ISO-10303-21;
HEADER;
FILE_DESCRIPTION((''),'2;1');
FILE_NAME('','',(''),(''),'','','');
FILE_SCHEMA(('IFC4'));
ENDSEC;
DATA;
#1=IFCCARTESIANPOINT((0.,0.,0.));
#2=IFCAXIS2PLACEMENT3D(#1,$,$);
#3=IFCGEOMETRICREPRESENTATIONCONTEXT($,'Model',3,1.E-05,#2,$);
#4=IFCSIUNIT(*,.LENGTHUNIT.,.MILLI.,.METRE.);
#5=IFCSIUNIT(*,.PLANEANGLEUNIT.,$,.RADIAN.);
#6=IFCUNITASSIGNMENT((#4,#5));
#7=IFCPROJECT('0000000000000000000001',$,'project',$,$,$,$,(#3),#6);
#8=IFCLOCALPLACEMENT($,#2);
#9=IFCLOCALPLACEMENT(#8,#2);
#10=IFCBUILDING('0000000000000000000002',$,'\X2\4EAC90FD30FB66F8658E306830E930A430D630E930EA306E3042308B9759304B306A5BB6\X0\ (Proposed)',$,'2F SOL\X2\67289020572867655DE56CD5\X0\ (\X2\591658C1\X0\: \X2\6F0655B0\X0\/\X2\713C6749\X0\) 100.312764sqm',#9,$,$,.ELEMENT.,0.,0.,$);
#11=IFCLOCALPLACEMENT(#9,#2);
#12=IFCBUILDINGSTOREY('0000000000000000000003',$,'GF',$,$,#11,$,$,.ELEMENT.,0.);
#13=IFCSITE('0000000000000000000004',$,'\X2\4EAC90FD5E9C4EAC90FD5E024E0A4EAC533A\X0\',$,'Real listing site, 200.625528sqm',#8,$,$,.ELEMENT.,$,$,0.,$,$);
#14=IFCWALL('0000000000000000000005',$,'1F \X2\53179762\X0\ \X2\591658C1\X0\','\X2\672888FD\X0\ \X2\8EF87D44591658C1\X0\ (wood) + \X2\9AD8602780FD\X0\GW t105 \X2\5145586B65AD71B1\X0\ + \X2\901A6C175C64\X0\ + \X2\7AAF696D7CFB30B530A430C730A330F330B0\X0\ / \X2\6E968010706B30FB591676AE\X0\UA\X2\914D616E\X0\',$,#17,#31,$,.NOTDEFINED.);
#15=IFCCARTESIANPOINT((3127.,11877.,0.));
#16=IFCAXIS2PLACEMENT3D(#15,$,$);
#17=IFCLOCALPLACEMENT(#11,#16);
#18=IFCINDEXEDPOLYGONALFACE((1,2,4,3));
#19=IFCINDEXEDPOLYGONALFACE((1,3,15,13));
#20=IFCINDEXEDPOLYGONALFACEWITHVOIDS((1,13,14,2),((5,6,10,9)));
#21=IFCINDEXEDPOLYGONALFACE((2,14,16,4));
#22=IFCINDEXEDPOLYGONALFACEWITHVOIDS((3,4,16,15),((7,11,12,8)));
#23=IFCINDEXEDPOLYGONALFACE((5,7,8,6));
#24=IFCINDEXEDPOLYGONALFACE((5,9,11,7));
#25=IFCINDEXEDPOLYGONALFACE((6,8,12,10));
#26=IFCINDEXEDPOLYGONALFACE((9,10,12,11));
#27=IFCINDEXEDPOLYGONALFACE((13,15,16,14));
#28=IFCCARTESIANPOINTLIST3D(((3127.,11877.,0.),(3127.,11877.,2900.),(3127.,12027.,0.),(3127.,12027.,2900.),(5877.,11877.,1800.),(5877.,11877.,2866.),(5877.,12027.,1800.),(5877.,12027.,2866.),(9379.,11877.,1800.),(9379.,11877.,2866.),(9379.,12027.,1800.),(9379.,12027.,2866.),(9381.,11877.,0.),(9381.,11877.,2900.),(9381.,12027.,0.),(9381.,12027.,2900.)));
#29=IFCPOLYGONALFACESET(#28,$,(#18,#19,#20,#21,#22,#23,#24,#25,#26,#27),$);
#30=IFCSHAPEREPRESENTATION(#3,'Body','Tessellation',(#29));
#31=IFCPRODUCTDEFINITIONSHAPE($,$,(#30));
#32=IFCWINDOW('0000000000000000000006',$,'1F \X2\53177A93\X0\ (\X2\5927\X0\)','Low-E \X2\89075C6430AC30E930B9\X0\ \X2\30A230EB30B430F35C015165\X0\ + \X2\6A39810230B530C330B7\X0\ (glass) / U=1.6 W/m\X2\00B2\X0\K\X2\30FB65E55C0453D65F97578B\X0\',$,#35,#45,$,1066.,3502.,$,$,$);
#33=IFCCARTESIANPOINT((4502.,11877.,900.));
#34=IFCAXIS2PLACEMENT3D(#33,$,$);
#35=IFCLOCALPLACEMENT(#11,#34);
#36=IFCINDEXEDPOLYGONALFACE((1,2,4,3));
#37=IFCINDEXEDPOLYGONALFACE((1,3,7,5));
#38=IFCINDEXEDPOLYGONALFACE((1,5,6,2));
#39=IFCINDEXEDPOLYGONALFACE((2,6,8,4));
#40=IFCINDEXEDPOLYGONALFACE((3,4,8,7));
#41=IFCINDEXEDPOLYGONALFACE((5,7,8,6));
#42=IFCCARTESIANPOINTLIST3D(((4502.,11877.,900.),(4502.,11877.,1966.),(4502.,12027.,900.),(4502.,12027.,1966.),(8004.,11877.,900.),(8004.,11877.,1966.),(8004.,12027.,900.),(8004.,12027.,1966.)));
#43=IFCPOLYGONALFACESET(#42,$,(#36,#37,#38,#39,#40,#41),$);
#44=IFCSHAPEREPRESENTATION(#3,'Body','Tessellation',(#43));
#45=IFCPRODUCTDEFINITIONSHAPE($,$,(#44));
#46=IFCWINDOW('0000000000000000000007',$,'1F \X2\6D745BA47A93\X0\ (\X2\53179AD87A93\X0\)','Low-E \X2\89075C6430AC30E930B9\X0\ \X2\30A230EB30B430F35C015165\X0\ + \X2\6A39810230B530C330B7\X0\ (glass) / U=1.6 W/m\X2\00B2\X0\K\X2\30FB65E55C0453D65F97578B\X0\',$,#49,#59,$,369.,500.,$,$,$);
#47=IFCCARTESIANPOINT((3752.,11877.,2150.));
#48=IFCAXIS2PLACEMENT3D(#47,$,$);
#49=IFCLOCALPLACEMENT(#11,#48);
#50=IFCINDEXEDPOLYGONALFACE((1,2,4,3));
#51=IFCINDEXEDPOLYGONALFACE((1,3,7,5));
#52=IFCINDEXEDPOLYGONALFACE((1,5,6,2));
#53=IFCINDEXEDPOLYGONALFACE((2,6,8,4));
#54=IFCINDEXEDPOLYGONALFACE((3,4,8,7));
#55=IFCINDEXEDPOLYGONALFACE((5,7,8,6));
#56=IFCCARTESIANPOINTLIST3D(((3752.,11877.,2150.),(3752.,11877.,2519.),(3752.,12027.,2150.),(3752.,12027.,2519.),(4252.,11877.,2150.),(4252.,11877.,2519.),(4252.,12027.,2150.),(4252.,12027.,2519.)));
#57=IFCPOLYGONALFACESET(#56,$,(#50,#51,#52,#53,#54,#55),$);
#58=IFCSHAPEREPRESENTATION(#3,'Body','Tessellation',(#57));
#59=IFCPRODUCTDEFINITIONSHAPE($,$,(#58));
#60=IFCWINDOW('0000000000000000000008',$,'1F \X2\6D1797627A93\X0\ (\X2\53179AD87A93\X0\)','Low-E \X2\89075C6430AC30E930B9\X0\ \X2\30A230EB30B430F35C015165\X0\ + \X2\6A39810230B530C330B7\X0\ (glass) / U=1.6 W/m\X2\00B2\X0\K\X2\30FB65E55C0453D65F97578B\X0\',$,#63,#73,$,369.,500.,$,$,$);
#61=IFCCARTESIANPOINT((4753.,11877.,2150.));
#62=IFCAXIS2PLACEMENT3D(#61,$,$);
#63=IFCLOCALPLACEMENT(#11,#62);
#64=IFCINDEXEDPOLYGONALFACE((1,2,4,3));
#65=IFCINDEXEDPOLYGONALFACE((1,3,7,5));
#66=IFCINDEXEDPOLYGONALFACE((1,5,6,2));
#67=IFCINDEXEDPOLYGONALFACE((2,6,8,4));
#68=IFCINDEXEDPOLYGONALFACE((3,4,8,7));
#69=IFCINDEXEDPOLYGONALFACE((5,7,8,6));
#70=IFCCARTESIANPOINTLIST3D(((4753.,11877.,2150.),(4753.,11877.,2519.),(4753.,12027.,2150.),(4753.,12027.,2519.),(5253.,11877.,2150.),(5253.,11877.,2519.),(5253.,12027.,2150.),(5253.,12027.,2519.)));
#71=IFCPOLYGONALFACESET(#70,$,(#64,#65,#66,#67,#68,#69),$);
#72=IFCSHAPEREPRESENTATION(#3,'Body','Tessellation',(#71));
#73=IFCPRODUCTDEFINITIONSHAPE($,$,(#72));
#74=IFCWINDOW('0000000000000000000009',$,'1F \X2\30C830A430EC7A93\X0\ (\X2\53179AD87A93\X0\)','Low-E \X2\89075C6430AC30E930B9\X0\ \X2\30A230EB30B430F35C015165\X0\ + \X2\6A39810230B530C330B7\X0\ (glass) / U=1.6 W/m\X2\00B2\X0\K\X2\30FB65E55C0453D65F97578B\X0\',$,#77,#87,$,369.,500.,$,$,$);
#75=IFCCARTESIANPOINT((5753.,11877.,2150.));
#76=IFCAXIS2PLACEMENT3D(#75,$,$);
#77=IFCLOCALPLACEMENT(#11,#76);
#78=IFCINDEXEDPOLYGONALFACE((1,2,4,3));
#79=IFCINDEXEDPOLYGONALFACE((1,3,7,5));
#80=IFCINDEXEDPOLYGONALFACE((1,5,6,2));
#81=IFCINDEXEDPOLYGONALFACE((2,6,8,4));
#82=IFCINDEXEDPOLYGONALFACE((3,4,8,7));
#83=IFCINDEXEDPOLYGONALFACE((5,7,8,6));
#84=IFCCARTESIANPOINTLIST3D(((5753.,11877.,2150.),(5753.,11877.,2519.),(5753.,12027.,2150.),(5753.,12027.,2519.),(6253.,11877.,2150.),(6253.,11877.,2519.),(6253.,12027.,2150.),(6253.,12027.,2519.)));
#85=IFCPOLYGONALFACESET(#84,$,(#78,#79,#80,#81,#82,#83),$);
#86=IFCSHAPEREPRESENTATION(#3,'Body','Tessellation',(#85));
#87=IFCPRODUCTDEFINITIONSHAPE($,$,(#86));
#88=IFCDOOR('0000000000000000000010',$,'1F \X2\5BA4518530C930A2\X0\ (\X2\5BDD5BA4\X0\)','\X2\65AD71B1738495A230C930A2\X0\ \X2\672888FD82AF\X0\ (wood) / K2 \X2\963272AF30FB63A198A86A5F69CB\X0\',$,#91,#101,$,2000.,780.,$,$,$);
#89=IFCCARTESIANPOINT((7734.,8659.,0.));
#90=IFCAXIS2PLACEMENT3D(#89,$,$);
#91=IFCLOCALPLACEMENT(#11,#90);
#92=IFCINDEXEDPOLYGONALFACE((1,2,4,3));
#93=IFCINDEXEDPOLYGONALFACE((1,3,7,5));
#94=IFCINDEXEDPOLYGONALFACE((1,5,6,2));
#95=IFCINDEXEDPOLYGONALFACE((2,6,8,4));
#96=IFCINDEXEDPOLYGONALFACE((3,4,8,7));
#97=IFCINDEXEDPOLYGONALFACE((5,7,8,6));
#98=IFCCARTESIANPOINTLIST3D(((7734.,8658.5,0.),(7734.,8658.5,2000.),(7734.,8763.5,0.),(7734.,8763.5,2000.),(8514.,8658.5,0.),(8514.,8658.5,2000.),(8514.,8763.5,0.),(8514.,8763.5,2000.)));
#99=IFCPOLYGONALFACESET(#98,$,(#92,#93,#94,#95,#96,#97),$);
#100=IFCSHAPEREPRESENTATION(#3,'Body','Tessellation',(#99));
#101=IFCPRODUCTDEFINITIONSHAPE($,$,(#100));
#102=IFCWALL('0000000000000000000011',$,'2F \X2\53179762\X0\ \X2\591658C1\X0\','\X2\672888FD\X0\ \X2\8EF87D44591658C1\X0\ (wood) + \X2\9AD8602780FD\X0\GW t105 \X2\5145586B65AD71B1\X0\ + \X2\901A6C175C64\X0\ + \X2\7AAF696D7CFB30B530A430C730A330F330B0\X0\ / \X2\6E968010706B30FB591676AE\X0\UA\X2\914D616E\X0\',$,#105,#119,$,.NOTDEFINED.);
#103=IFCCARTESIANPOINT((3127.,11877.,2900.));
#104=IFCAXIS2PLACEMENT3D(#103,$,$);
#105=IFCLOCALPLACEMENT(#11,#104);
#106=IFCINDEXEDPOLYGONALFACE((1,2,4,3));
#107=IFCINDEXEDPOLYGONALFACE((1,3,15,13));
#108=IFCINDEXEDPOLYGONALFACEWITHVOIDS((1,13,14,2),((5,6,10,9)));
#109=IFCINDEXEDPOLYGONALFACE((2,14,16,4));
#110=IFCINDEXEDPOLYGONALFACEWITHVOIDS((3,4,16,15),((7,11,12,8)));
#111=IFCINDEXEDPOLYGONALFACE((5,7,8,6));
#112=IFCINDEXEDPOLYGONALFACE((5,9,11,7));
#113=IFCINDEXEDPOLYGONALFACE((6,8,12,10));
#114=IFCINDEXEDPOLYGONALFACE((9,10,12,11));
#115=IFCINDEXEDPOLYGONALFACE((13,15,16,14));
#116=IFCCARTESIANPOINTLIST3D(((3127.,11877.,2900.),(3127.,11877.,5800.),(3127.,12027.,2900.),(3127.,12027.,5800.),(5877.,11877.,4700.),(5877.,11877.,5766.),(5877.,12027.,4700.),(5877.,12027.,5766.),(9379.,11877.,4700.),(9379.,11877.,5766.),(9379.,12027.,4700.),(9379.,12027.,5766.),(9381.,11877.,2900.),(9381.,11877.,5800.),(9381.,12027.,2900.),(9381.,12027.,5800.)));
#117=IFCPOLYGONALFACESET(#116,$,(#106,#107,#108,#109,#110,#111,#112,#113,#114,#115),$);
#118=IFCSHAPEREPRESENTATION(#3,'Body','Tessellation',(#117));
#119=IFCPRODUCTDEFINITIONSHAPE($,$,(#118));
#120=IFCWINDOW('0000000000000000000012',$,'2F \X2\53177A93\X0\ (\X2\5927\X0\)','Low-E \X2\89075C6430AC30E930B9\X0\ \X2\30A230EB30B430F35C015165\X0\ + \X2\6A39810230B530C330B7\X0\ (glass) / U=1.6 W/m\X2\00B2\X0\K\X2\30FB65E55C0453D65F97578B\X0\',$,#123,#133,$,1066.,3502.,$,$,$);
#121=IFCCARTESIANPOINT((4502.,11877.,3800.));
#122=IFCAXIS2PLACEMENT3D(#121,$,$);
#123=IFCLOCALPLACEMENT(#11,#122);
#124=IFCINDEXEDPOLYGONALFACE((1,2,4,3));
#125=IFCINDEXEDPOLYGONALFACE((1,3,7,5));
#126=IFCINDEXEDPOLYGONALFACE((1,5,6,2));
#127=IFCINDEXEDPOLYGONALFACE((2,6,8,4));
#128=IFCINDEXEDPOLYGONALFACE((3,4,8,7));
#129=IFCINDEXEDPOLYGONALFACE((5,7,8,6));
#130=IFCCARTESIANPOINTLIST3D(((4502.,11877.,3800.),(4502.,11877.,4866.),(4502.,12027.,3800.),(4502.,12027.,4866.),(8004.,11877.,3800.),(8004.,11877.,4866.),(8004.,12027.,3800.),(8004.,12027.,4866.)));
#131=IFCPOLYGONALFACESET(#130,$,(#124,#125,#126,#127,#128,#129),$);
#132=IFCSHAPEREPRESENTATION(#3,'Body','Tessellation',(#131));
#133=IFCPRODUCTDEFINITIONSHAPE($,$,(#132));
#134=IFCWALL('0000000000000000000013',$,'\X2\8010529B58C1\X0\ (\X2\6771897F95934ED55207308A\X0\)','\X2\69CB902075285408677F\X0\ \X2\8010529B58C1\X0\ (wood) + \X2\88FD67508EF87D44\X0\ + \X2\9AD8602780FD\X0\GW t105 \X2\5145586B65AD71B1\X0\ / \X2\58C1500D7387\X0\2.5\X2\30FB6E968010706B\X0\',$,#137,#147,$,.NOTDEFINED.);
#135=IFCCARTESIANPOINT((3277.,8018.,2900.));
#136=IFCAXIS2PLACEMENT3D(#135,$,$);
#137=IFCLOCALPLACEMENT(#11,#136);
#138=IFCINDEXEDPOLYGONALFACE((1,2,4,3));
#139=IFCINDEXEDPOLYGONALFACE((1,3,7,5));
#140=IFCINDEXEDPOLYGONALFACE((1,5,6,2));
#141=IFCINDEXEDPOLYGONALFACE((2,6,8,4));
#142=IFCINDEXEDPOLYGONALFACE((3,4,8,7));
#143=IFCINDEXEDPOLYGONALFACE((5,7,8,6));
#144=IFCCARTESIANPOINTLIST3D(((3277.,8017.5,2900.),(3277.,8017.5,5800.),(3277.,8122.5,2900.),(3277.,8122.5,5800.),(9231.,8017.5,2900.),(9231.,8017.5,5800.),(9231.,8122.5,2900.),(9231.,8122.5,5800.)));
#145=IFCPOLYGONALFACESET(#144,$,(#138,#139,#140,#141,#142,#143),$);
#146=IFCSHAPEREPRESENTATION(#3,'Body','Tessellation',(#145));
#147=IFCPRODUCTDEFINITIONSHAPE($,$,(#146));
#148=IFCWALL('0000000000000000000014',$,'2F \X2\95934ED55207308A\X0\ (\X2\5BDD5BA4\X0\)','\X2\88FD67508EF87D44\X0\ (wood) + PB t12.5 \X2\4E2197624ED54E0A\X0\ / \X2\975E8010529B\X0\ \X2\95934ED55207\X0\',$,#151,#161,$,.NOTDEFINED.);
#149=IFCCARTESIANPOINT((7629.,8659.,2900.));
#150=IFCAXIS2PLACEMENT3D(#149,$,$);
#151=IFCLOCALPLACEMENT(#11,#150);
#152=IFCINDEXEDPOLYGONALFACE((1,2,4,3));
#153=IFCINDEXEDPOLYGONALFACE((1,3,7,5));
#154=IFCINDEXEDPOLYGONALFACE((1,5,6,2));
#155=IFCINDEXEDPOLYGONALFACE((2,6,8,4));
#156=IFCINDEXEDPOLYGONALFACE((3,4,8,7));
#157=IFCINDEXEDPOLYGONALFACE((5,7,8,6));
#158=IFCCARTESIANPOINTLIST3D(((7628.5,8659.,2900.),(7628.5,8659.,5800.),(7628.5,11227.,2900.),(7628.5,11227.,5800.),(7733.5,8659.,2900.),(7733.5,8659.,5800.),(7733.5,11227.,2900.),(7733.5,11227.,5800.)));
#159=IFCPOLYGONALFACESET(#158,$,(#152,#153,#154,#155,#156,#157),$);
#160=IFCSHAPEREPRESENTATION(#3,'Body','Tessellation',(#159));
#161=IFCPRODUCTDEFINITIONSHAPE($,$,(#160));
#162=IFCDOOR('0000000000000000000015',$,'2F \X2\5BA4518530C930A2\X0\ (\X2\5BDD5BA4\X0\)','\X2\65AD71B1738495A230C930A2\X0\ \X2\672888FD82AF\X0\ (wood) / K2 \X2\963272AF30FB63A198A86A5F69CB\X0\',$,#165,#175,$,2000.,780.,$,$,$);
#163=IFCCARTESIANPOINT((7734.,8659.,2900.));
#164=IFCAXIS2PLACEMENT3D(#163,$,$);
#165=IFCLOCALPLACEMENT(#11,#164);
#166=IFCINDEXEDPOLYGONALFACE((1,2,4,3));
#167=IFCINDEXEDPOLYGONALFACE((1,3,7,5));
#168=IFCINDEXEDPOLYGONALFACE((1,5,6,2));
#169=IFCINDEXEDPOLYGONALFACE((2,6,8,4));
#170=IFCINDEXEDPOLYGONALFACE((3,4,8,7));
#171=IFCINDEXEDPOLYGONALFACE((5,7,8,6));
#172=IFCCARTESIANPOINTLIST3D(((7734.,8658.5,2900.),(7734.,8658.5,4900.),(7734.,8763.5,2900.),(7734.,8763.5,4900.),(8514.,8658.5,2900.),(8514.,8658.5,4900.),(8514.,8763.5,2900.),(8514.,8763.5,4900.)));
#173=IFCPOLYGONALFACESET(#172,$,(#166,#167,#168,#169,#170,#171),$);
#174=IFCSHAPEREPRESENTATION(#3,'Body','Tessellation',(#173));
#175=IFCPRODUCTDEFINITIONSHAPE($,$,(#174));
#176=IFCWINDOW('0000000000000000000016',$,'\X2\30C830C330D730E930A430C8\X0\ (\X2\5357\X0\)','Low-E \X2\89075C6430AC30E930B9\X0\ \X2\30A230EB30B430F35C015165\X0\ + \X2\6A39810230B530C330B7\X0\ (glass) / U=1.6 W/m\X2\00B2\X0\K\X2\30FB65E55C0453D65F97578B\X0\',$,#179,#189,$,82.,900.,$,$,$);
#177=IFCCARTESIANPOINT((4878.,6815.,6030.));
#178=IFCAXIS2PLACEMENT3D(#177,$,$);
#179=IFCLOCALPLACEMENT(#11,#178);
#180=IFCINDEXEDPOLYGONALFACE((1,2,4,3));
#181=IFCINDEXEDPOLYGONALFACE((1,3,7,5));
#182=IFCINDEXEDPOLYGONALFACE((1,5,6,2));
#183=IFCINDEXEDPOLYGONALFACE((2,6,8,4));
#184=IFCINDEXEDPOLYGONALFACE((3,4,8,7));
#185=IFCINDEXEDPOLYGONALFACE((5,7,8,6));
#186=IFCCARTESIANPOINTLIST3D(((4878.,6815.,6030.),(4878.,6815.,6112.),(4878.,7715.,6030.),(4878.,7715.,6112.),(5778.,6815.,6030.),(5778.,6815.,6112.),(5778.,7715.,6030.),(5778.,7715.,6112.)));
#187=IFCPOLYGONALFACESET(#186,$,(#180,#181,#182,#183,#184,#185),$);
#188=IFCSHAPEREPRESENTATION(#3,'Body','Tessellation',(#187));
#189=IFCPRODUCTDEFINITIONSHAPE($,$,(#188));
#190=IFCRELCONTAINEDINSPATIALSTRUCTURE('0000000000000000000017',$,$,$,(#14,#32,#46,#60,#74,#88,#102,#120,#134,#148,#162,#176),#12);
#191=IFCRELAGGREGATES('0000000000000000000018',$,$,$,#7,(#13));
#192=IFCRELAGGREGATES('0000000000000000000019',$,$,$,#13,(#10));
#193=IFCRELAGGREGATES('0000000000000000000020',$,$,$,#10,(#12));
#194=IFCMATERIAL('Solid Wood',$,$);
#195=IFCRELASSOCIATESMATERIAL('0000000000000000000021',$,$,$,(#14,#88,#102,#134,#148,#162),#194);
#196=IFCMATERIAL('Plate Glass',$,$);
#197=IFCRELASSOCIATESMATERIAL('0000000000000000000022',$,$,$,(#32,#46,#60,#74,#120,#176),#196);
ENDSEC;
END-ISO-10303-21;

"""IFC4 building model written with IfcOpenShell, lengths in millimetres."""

from ifc_helpers import new_model, si_unit, frame, frame_2d, origin, place, context, project, spatial, rectangle, extrude, material, element, fill, save


model = new_model("IFC4")

# Units and contexts
model_context = context("Model", 3, precision=1e-05, world=origin())
ifc_project = project(units=[si_unit("LENGTHUNIT", "METRE", prefix="MILLI"), si_unit("PLANEANGLEUNIT", "RADIAN")], contexts=[model_context])

# Site, building, storey
site_placement = place(None, origin())
site = spatial("IfcSite", under=ifc_project, at=site_placement, Name="京都府京都市上京区", ObjectType="Real listing site, 200.625528sqm", CompositionType="ELEMENT", RefElevation=0.0)
building_placement = place(site_placement, origin())
building = spatial("IfcBuilding", under=site, at=building_placement, Name="京都・書斎とライブラリのある静かな家 (Proposed)", ObjectType="2F SOL木造在来工法 (外壁: 漆喰/焼杉) 100.312764sqm", CompositionType="ELEMENT", ElevationOfRefHeight=0.0, ElevationOfTerrain=0.0)
storey_placement = place(building_placement, origin())
storey = spatial("IfcBuildingStorey", under=building, at=storey_placement, Name="GF", CompositionType="ELEMENT", Elevation=0.0)

# Wall, openings, windows
ifc_material_1 = material(Name="Solid Wood")
wall_1_placement = place(storey_placement, frame((3127.0, 11877.0, 0.0)))
wall_1 = element("IfcWall", 1, at=wall_1_placement, inside=storey, material=ifc_material_1, Name="1F 北面 外壁", Description="木製 軸組外壁 (wood) + 高性能GW t105 充填断熱 + 通気層 + 窯業系サイディング / 準耐火・外皮UA配慮", PredefinedType="NOTDEFINED", context=model_context, shape_type="SweptSolid", body=[
    extrude(rectangle(XDim=6254.0, YDim=150.0, at=frame_2d((3127.0, 75.0))), frame((3127.0, 11877.0, 0.0)), (0.0, 0.0, 1.0), 2900.0),
])
opening_1_placement = place(storey_placement, frame((4502.0, 11877.0, 900.0)))
opening_1 = element("IfcOpeningElement", 2, at=opening_1_placement, cuts=wall_1, PredefinedType="NOTDEFINED", context=model_context, shape_type="SweptSolid", body=[
    extrude(rectangle(XDim=3502.0, YDim=150.0, at=frame_2d((1751.0, 75.0))), frame((4502.0, 11877.0, 900.0)), (0.0, 0.0, 1.0), 1066.0),
])
opening_2_placement = place(storey_placement, frame((3752.0, 11877.0, 2150.0)))
opening_2 = element("IfcOpeningElement", 3, at=opening_2_placement, cuts=wall_1, PredefinedType="NOTDEFINED", context=model_context, shape_type="SweptSolid", body=[
    extrude(rectangle(XDim=500.0, YDim=150.0, at=frame_2d((250.0, 75.0))), frame((3752.0, 11877.0, 2150.0)), (0.0, 0.0, 1.0), 369.0),
])
opening_3_placement = place(storey_placement, frame((4753.0, 11877.0, 2150.0)))
opening_3 = element("IfcOpeningElement", 4, at=opening_3_placement, cuts=wall_1, PredefinedType="NOTDEFINED", context=model_context, shape_type="SweptSolid", body=[
    extrude(rectangle(XDim=500.0, YDim=150.0, at=frame_2d((250.0, 75.0))), frame((4753.0, 11877.0, 2150.0)), (0.0, 0.0, 1.0), 369.0),
])
opening_4_placement = place(storey_placement, frame((5753.0, 11877.0, 2150.0)))
opening_4 = element("IfcOpeningElement", 5, at=opening_4_placement, cuts=wall_1, PredefinedType="NOTDEFINED", context=model_context, shape_type="SweptSolid", body=[
    extrude(rectangle(XDim=500.0, YDim=150.0, at=frame_2d((250.0, 75.0))), frame((5753.0, 11877.0, 2150.0)), (0.0, 0.0, 1.0), 369.0),
])
ifc_material_2 = material(Name="Plate Glass")
window_1_placement = place(storey_placement, frame((4502.0, 11877.0, 900.0)))
window_1 = element("IfcWindow", 6, at=window_1_placement, inside=storey, material=ifc_material_2, Name="1F 北窓 (大)", Description="Low-E 複層ガラス アルゴン封入 + 樹脂サッシ (glass) / U=1.6 W/m²K・日射取得型", OverallHeight=1066.0, OverallWidth=3502.0, context=model_context, shape_type="SweptSolid", body=[
    extrude(rectangle(XDim=3502.0, YDim=150.0, at=frame_2d((1751.0, 75.0))), frame((4502.0, 11877.0, 900.0)), (0.0, 0.0, 1.0), 1066.0),
])
fill(opening_1, window_1)
window_2_placement = place(storey_placement, frame((3752.0, 11877.0, 2150.0)))
window_2 = element("IfcWindow", 7, at=window_2_placement, inside=storey, material=ifc_material_2, Name="1F 浴室窓 (北高窓)", Description="Low-E 複層ガラス アルゴン封入 + 樹脂サッシ (glass) / U=1.6 W/m²K・日射取得型", OverallHeight=369.0, OverallWidth=500.0, context=model_context, shape_type="SweptSolid", body=[
    extrude(rectangle(XDim=500.0, YDim=150.0, at=frame_2d((250.0, 75.0))), frame((3752.0, 11877.0, 2150.0)), (0.0, 0.0, 1.0), 369.0),
])
fill(opening_2, window_2)
window_3_placement = place(storey_placement, frame((4753.0, 11877.0, 2150.0)))
window_3 = element("IfcWindow", 8, at=window_3_placement, inside=storey, material=ifc_material_2, Name="1F 洗面窓 (北高窓)", Description="Low-E 複層ガラス アルゴン封入 + 樹脂サッシ (glass) / U=1.6 W/m²K・日射取得型", OverallHeight=369.0, OverallWidth=500.0, context=model_context, shape_type="SweptSolid", body=[
    extrude(rectangle(XDim=500.0, YDim=150.0, at=frame_2d((250.0, 75.0))), frame((4753.0, 11877.0, 2150.0)), (0.0, 0.0, 1.0), 369.0),
])
fill(opening_3, window_3)
window_4_placement = place(storey_placement, frame((5753.0, 11877.0, 2150.0)))
window_4 = element("IfcWindow", 9, at=window_4_placement, inside=storey, material=ifc_material_2, Name="1F トイレ窓 (北高窓)", Description="Low-E 複層ガラス アルゴン封入 + 樹脂サッシ (glass) / U=1.6 W/m²K・日射取得型", OverallHeight=369.0, OverallWidth=500.0, context=model_context, shape_type="SweptSolid", body=[
    extrude(rectangle(XDim=500.0, YDim=150.0, at=frame_2d((250.0, 75.0))), frame((5753.0, 11877.0, 2150.0)), (0.0, 0.0, 1.0), 369.0),
])
fill(opening_4, window_4)

# Door
door_1_placement = place(storey_placement, frame((7734.0, 8659.0, 0.0)))
element("IfcDoor", 10, at=door_1_placement, inside=storey, material=ifc_material_1, Name="1F 室内ドア (寝室)", Description="断熱玄関ドア 木製芯 (wood) / K2 防犯・採風機構", OverallHeight=2000.0, OverallWidth=780.0, context=model_context, shape_type="SweptSolid", body=[
    extrude(rectangle(XDim=780.0, YDim=105.0, at=frame_2d((390.0, 52.0))), frame((7734.0, 8659.0, 0.0)), (0.0, 0.0, 1.0), 2000.0),
])

# Wall, opening, window
wall_2_placement = place(storey_placement, frame((3127.0, 11877.0, 2900.0)))
wall_2 = element("IfcWall", 11, at=wall_2_placement, inside=storey, material=ifc_material_1, Name="2F 北面 外壁", Description="木製 軸組外壁 (wood) + 高性能GW t105 充填断熱 + 通気層 + 窯業系サイディング / 準耐火・外皮UA配慮", PredefinedType="NOTDEFINED", context=model_context, shape_type="SweptSolid", body=[
    extrude(rectangle(XDim=6254.0, YDim=150.0, at=frame_2d((3127.0, 75.0))), frame((3127.0, 11877.0, 2900.0)), (0.0, 0.0, 1.0), 2900.0),
])
opening_5_placement = place(storey_placement, frame((4502.0, 11877.0, 3800.0)))
opening_5 = element("IfcOpeningElement", 12, at=opening_5_placement, cuts=wall_2, PredefinedType="NOTDEFINED", context=model_context, shape_type="SweptSolid", body=[
    extrude(rectangle(XDim=3502.0, YDim=150.0, at=frame_2d((1751.0, 75.0))), frame((4502.0, 11877.0, 3800.0)), (0.0, 0.0, 1.0), 1066.0),
])
window_5_placement = place(storey_placement, frame((4502.0, 11877.0, 3800.0)))
window_5 = element("IfcWindow", 13, at=window_5_placement, inside=storey, material=ifc_material_2, Name="2F 北窓 (大)", Description="Low-E 複層ガラス アルゴン封入 + 樹脂サッシ (glass) / U=1.6 W/m²K・日射取得型", OverallHeight=1066.0, OverallWidth=3502.0, context=model_context, shape_type="SweptSolid", body=[
    extrude(rectangle(XDim=3502.0, YDim=150.0, at=frame_2d((1751.0, 75.0))), frame((4502.0, 11877.0, 3800.0)), (0.0, 0.0, 1.0), 1066.0),
])
fill(opening_5, window_5)

# Walls
wall_3_placement = place(storey_placement, frame((3277.0, 8018.0, 2900.0)))
element("IfcWall", 14, at=wall_3_placement, inside=storey, material=ifc_material_1, Name="耐力壁 (東西間仕切り)", Description="構造用合板 耐力壁 (wood) + 製材軸組 + 高性能GW t105 充填断熱 / 壁倍率2.5・準耐火", PredefinedType="NOTDEFINED", context=model_context, shape_type="SweptSolid", body=[
    extrude(rectangle(XDim=5954.0, YDim=105.0, at=frame_2d((2977.0, 52.0))), frame((3277.0, 8018.0, 2900.0)), (0.0, 0.0, 1.0), 2900.0),
])
wall_4_placement = place(storey_placement, frame((7629.0, 8659.0, 2900.0)))
element("IfcWall", 15, at=wall_4_placement, inside=storey, material=ifc_material_1, Name="2F 間仕切り (寝室)", Description="製材軸組 (wood) + PB t12.5 両面仕上 / 非耐力 間仕切", PredefinedType="NOTDEFINED", context=model_context, shape_type="SweptSolid", body=[
    extrude(rectangle(XDim=105.0, YDim=2568.0, at=frame_2d((52.0, 1284.0))), frame((7629.0, 8659.0, 2900.0)), (0.0, 0.0, 1.0), 2900.0),
])

# Door
door_2_placement = place(storey_placement, frame((7734.0, 8659.0, 2900.0)))
element("IfcDoor", 16, at=door_2_placement, inside=storey, material=ifc_material_1, Name="2F 室内ドア (寝室)", Description="断熱玄関ドア 木製芯 (wood) / K2 防犯・採風機構", OverallHeight=2000.0, OverallWidth=780.0, context=model_context, shape_type="SweptSolid", body=[
    extrude(rectangle(XDim=780.0, YDim=105.0, at=frame_2d((390.0, 52.0))), frame((7734.0, 8659.0, 2900.0)), (0.0, 0.0, 1.0), 2000.0),
])

# Window
window_6_placement = place(storey_placement, frame((4878.0, 6815.0, 6030.0)))
element("IfcWindow", 17, at=window_6_placement, inside=storey, material=ifc_material_2, Name="トップライト (南)", Description="Low-E 複層ガラス アルゴン封入 + 樹脂サッシ (glass) / U=1.6 W/m²K・日射取得型", OverallHeight=82.0, OverallWidth=900.0, context=model_context, shape_type="SweptSolid", body=[
    extrude(rectangle(XDim=900.0, YDim=900.0, at=frame_2d((450.0, 450.0))), frame((4878.0, 6815.0, 6030.0)), (0.0, 0.0, 1.0), 82.0),
])

save(model, "model.ifc")
